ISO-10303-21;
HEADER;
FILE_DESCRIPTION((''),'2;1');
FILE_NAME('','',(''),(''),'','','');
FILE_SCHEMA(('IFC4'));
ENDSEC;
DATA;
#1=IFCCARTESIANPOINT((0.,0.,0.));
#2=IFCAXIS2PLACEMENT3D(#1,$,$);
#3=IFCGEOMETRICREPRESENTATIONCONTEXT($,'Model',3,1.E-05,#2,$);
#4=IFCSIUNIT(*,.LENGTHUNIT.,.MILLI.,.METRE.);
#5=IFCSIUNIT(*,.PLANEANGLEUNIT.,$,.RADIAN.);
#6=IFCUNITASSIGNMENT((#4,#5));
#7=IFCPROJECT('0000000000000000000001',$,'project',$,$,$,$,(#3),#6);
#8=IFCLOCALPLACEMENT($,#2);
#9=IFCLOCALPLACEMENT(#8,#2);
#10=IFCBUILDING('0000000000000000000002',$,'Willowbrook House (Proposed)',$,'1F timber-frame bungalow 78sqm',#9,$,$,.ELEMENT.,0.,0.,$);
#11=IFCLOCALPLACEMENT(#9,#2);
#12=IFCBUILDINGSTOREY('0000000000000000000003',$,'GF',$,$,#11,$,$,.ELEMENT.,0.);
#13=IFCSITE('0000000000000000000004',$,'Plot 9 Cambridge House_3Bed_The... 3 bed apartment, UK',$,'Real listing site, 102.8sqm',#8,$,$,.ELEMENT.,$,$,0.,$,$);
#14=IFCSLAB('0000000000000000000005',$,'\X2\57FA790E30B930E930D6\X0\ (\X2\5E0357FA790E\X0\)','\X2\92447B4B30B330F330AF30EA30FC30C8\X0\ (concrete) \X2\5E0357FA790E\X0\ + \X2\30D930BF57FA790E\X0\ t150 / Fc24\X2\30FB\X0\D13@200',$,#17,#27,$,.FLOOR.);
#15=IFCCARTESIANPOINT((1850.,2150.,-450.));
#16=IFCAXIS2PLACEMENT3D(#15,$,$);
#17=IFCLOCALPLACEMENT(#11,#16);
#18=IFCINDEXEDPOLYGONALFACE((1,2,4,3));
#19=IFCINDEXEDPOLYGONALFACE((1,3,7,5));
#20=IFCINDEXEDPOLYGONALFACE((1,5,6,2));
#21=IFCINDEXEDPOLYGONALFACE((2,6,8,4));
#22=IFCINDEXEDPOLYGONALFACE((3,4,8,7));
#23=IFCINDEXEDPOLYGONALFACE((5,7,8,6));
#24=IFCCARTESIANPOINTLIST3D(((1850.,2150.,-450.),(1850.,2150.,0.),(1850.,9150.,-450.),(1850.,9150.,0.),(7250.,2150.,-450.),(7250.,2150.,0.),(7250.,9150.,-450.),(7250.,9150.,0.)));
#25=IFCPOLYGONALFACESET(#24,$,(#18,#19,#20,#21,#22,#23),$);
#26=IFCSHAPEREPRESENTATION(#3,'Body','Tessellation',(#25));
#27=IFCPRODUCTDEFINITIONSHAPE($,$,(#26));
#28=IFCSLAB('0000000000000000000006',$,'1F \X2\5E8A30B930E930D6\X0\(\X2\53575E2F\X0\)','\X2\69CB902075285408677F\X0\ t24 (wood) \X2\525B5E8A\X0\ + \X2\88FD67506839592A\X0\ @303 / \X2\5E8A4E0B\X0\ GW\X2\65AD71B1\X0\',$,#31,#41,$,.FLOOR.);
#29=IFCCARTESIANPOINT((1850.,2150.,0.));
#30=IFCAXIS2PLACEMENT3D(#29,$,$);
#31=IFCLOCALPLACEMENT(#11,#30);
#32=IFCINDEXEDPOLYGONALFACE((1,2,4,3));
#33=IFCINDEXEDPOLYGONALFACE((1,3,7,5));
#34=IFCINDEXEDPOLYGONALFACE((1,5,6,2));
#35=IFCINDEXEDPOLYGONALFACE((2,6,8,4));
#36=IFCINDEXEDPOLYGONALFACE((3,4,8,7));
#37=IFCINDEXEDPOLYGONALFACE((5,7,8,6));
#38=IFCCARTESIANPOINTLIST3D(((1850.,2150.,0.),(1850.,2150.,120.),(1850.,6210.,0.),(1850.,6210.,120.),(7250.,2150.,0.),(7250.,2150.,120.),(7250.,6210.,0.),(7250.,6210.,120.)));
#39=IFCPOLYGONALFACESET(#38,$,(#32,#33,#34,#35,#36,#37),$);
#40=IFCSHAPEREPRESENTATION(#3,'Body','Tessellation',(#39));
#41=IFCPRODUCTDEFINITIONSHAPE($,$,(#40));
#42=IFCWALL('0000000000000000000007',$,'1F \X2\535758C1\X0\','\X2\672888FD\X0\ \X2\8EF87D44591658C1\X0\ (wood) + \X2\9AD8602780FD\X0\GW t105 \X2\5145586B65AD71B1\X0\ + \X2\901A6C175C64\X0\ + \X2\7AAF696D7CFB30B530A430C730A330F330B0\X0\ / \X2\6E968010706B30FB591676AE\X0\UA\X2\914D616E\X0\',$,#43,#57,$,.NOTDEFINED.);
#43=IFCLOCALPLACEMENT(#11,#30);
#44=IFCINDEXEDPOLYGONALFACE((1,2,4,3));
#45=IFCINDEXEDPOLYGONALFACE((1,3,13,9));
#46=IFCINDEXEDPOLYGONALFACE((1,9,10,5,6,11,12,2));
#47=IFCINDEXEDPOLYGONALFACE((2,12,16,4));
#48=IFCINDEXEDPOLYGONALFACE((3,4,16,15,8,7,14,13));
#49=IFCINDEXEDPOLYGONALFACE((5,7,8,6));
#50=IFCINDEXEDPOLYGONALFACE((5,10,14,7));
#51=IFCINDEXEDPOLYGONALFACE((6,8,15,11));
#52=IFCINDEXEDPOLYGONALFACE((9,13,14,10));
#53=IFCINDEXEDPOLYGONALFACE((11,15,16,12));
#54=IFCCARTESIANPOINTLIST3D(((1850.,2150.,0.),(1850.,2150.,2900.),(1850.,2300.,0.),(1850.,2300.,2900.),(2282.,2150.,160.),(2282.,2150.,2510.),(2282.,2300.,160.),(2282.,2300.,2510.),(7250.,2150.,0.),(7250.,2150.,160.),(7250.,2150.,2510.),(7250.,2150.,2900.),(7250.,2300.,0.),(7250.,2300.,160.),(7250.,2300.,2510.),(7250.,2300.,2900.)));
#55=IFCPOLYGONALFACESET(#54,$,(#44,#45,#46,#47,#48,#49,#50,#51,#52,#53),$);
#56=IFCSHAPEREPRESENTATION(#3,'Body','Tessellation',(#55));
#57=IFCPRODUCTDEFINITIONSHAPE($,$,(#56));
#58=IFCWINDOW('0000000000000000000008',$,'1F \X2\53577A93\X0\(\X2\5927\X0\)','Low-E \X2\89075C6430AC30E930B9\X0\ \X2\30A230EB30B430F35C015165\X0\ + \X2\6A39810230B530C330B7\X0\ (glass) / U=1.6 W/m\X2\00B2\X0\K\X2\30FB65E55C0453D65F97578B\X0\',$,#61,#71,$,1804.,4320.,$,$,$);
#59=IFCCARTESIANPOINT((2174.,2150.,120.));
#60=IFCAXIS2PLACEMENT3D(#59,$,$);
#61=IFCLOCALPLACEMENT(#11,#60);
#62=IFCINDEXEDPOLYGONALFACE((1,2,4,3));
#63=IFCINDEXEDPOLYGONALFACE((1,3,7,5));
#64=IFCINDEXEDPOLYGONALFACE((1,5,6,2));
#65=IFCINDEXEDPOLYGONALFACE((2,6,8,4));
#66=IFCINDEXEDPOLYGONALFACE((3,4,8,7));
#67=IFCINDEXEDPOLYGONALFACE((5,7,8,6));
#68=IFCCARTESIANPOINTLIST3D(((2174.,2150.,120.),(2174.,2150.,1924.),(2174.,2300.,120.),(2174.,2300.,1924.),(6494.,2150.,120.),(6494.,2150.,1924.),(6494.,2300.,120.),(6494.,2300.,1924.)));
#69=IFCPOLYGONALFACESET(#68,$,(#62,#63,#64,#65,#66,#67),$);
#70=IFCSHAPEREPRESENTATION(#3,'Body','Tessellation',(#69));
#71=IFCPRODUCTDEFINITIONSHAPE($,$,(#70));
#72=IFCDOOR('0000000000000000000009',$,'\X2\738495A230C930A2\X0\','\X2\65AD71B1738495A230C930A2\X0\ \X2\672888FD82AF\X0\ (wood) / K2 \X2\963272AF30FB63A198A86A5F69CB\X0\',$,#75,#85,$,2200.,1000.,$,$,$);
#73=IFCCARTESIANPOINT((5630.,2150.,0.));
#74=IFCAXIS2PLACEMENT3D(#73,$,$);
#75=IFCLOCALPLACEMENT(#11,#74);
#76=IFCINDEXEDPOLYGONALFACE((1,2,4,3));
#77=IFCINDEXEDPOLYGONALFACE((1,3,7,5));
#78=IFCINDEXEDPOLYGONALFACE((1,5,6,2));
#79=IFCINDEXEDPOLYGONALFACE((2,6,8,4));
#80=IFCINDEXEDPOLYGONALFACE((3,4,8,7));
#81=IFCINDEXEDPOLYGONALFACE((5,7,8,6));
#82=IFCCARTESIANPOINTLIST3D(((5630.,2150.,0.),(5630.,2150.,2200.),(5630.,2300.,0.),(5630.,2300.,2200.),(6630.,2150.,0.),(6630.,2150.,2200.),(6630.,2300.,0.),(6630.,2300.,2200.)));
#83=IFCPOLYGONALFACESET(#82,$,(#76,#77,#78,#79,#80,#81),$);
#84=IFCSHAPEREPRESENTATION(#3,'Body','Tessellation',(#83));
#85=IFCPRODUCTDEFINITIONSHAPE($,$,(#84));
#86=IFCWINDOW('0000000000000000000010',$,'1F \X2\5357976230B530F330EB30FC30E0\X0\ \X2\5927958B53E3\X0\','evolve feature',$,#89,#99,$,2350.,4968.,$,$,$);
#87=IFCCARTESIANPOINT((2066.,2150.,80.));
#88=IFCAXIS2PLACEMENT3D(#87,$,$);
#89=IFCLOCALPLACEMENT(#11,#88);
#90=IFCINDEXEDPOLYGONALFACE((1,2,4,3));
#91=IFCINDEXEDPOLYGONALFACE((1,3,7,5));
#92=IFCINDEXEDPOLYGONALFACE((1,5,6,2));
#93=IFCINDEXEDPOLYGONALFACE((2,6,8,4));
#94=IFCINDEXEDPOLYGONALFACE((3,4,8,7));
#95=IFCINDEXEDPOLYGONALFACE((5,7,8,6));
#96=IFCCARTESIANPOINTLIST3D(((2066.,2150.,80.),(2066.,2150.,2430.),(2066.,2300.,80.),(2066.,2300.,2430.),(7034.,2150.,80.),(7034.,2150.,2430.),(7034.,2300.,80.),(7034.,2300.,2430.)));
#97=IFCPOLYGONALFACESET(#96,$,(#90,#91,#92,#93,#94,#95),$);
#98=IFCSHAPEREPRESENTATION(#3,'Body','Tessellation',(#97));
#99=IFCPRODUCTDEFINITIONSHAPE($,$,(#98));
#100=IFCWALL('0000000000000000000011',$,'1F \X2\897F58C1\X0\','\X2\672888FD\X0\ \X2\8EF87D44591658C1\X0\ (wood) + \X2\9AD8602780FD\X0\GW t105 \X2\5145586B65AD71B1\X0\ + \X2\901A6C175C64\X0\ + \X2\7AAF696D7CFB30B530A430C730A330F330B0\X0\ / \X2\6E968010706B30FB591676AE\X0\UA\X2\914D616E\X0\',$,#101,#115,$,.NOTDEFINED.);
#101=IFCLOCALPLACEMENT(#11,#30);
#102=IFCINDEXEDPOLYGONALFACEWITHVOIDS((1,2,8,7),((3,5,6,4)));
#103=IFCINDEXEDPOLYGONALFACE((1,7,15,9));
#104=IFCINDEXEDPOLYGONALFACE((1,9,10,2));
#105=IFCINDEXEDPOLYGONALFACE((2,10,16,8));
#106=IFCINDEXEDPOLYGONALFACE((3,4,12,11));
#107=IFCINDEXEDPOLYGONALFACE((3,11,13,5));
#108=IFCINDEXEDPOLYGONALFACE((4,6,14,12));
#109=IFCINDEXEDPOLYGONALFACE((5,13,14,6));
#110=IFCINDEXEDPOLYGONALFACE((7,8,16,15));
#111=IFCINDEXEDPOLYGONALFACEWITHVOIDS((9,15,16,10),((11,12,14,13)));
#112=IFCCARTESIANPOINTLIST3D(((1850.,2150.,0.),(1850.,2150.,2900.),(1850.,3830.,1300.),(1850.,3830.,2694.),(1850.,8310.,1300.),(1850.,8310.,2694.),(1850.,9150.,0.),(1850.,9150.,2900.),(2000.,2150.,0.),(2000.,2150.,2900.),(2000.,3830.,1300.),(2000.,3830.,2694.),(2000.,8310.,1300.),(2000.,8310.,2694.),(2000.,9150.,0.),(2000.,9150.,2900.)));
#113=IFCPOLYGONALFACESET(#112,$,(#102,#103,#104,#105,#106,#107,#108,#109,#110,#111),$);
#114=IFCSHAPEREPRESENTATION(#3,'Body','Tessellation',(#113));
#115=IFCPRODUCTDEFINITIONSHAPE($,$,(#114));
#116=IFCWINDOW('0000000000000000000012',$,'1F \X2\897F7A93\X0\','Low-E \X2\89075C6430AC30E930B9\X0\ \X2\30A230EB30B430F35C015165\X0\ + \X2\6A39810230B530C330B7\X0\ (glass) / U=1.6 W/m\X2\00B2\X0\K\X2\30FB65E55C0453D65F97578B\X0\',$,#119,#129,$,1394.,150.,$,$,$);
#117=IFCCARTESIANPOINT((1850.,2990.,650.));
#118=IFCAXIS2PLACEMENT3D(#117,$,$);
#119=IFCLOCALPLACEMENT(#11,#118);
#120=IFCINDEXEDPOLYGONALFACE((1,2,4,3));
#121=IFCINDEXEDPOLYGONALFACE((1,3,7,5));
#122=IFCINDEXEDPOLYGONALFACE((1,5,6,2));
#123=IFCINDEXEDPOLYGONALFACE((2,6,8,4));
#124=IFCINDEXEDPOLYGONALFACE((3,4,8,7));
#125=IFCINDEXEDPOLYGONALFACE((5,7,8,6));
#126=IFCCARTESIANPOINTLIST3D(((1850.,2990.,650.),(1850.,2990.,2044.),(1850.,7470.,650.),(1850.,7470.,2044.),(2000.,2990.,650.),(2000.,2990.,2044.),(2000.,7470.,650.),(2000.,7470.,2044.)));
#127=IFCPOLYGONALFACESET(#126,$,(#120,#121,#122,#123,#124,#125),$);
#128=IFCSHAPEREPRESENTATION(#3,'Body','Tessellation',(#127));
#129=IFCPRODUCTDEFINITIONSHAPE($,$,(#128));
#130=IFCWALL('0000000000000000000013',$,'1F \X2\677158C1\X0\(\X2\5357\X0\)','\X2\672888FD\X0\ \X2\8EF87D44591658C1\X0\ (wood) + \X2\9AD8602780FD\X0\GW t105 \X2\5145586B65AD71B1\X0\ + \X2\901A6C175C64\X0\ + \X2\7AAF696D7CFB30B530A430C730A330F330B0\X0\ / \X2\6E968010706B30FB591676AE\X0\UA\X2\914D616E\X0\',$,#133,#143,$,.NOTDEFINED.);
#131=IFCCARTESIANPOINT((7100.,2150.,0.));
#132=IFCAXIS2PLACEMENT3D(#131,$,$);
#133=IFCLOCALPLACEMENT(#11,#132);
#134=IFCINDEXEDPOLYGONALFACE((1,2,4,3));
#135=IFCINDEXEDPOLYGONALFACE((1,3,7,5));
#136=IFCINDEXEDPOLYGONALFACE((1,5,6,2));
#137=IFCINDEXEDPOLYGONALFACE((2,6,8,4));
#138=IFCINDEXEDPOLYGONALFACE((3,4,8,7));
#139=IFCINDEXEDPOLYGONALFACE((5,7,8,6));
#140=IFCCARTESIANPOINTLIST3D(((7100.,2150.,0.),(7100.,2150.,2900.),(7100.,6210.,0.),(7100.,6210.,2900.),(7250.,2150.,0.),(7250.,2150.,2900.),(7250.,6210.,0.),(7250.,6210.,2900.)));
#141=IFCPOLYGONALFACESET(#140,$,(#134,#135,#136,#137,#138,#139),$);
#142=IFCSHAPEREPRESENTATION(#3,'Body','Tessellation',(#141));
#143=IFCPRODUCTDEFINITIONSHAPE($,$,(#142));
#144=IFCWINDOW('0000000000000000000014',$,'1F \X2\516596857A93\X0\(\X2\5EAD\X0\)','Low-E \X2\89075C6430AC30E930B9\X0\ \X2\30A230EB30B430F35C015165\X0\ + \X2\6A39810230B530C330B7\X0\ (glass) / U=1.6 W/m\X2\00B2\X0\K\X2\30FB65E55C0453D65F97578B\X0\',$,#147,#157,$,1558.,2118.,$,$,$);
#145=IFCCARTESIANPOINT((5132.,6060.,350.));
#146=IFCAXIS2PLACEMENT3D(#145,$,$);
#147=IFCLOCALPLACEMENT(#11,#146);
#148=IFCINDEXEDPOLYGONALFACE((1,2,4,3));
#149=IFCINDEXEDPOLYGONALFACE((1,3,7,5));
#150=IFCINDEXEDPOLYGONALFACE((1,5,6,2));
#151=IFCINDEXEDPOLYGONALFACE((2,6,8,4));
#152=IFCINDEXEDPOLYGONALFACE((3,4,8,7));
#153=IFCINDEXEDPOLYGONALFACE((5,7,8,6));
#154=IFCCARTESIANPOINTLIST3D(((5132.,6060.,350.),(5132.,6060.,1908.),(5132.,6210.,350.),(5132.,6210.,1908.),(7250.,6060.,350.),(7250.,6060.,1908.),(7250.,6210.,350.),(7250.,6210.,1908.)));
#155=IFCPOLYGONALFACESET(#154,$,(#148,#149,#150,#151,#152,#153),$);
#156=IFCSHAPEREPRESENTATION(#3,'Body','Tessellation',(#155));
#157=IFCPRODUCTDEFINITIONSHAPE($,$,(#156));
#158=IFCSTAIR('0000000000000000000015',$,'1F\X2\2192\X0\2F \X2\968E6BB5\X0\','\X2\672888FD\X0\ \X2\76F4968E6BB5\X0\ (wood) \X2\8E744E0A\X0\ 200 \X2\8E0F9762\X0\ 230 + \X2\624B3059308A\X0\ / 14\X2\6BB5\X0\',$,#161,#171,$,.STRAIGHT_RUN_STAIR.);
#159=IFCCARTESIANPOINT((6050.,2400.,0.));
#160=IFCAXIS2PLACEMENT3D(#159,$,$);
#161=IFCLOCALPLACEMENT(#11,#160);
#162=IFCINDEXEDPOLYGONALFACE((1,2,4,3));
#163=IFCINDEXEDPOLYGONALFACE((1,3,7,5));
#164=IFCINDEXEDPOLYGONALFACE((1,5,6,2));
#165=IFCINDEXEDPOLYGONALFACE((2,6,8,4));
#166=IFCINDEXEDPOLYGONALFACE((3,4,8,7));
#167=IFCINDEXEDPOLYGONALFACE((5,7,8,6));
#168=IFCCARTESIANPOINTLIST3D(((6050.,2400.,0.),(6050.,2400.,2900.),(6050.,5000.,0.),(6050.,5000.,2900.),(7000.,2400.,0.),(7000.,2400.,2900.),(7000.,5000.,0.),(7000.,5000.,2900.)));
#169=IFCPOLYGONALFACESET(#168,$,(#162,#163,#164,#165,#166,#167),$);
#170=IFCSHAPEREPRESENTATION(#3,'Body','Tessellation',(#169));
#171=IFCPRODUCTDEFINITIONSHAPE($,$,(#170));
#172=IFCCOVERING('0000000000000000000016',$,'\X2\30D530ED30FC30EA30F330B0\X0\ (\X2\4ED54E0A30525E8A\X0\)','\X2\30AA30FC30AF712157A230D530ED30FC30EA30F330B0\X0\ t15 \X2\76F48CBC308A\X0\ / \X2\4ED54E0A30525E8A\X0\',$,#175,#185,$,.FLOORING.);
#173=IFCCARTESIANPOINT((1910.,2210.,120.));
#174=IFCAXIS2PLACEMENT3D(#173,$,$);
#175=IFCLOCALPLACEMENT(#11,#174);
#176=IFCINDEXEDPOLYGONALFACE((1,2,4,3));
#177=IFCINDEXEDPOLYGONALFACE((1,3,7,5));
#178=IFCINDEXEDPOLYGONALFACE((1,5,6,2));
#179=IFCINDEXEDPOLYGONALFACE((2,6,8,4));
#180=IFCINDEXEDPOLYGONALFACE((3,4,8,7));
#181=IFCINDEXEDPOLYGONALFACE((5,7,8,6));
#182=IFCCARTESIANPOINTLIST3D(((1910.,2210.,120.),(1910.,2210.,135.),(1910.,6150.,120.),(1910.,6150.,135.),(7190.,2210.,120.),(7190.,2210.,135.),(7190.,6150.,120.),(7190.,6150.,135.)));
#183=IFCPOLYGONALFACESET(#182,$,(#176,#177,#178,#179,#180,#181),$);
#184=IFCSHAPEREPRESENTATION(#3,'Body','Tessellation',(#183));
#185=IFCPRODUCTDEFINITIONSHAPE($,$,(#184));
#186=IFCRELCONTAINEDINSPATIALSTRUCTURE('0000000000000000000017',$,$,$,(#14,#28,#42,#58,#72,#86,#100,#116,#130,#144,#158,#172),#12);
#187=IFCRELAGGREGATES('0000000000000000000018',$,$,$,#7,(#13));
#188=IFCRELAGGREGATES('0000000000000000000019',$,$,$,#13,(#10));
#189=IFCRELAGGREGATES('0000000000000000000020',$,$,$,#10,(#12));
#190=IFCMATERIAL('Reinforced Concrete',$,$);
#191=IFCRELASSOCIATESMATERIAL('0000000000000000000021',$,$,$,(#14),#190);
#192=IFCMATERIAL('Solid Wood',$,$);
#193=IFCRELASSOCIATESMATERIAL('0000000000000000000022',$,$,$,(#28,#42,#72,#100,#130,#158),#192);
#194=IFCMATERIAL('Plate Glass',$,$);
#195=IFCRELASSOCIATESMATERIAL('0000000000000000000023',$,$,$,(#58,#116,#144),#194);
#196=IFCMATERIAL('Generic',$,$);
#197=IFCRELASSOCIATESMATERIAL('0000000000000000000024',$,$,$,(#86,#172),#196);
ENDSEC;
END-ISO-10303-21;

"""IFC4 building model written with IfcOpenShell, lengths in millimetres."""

from ifc_helpers import new_model, si_unit, frame, frame_2d, origin, place, context, project, spatial, rectangle, extrude, material, element, fill, save


model = new_model("IFC4")

# Units and contexts
model_context = context("Model", 3, precision=1e-05, world=origin())
ifc_project = project(units=[si_unit("LENGTHUNIT", "METRE", prefix="MILLI"), si_unit("PLANEANGLEUNIT", "RADIAN")], contexts=[model_context])

# Site, building, storey
site_placement = place(None, origin())
site = spatial("IfcSite", under=ifc_project, at=site_placement, Name="Plot 9 Cambridge House_3Bed_The... 3 bed apartment, UK", ObjectType="Real listing site, 102.8sqm", CompositionType="ELEMENT", RefElevation=0.0)
building_placement = place(site_placement, origin())
building = spatial("IfcBuilding", under=site, at=building_placement, Name="Willowbrook House (Proposed)", ObjectType="1F timber-frame bungalow 78sqm", CompositionType="ELEMENT", ElevationOfRefHeight=0.0, ElevationOfTerrain=0.0)
storey_placement = place(building_placement, origin())
storey = spatial("IfcBuildingStorey", under=building, at=storey_placement, Name="GF", CompositionType="ELEMENT", Elevation=0.0)

# Slabs
ifc_material_1 = material(Name="Reinforced Concrete")
slab_1_placement = place(storey_placement, frame((1850.0, 2150.0, -450.0)))
element("IfcSlab", 1, at=slab_1_placement, inside=storey, material=ifc_material_1, Name="基礎スラブ (布基礎)", Description="鉄筋コンクリート (concrete) 布基礎 + ベタ基礎 t150 / Fc24・D13@200", PredefinedType="FLOOR", context=model_context, shape_type="SweptSolid", body=[
    extrude(rectangle(XDim=5400.0, YDim=7000.0, at=frame_2d((2700.0, 3500.0))), frame((1850.0, 2150.0, -450.0)), (0.0, 0.0, 1.0), 450.0),
])
ifc_material_2 = material(Name="Solid Wood")
slab_2_placement = place(storey_placement, frame((1850.0, 2150.0, 0.0)))
element("IfcSlab", 2, at=slab_2_placement, inside=storey, material=ifc_material_2, Name="1F 床スラブ(南帯)", Description="構造用合板 t24 (wood) 剛床 + 製材根太 @303 / 床下 GW断熱", PredefinedType="FLOOR", context=model_context, shape_type="SweptSolid", body=[
    extrude(rectangle(XDim=5400.0, YDim=4060.0, at=frame_2d((2700.0, 2030.0))), frame((1850.0, 2150.0, 0.0)), (0.0, 0.0, 1.0), 120.0),
])

# Wall, openings, windows, door
wall_1_placement = place(storey_placement, frame((1850.0, 2150.0, 0.0)))
wall_1 = element("IfcWall", 3, at=wall_1_placement, inside=storey, material=ifc_material_2, Name="1F 南壁", Description="木製 軸組外壁 (wood) + 高性能GW t105 充填断熱 + 通気層 + 窯業系サイディング / 準耐火・外皮UA配慮", PredefinedType="NOTDEFINED", context=model_context, shape_type="SweptSolid", body=[
    extrude(rectangle(XDim=5400.0, YDim=150.0, at=frame_2d((2700.0, 75.0))), frame((1850.0, 2150.0, 0.0)), (0.0, 0.0, 1.0), 2900.0),
])
opening_1_placement = place(storey_placement, frame((2174.0, 2150.0, 120.0)))
opening_1 = element("IfcOpeningElement", 4, at=opening_1_placement, cuts=wall_1, PredefinedType="NOTDEFINED", context=model_context, shape_type="SweptSolid", body=[
    extrude(rectangle(XDim=4320.0, YDim=150.0, at=frame_2d((2160.0, 75.0))), frame((2174.0, 2150.0, 120.0)), (0.0, 0.0, 1.0), 1804.0),
])
opening_2_placement = place(storey_placement, frame((5630.0, 2150.0, 0.0)))
opening_2 = element("IfcOpeningElement", 5, at=opening_2_placement, cuts=wall_1, PredefinedType="NOTDEFINED", context=model_context, shape_type="SweptSolid", body=[
    extrude(rectangle(XDim=1000.0, YDim=150.0, at=frame_2d((500.0, 75.0))), frame((5630.0, 2150.0, 0.0)), (0.0, 0.0, 1.0), 2200.0),
])
opening_3_placement = place(storey_placement, frame((2066.0, 2150.0, 80.0)))
opening_3 = element("IfcOpeningElement", 6, at=opening_3_placement, cuts=wall_1, PredefinedType="NOTDEFINED", context=model_context, shape_type="SweptSolid", body=[
    extrude(rectangle(XDim=4968.0, YDim=150.0, at=frame_2d((2484.0, 75.0))), frame((2066.0, 2150.0, 80.0)), (0.0, 0.0, 1.0), 2350.0),
])
ifc_material_3 = material(Name="Plate Glass")
window_1_placement = place(storey_placement, frame((2174.0, 2150.0, 120.0)))
window_1 = element("IfcWindow", 7, at=window_1_placement, inside=storey, material=ifc_material_3, Name="1F 南窓(大)", Description="Low-E 複層ガラス アルゴン封入 + 樹脂サッシ (glass) / U=1.6 W/m²K・日射取得型", OverallHeight=1804.0, OverallWidth=4320.0, context=model_context, shape_type="SweptSolid", body=[
    extrude(rectangle(XDim=4320.0, YDim=150.0, at=frame_2d((2160.0, 75.0))), frame((2174.0, 2150.0, 120.0)), (0.0, 0.0, 1.0), 1804.0),
])
fill(opening_1, window_1)
door_1_placement = place(storey_placement, frame((5630.0, 2150.0, 0.0)))
door_1 = element("IfcDoor", 8, at=door_1_placement, inside=storey, material=ifc_material_2, Name="玄関ドア", Description="断熱玄関ドア 木製芯 (wood) / K2 防犯・採風機構", OverallHeight=2200.0, OverallWidth=1000.0, context=model_context, shape_type="SweptSolid", body=[
    extrude(rectangle(XDim=1000.0, YDim=150.0, at=frame_2d((500.0, 75.0))), frame((5630.0, 2150.0, 0.0)), (0.0, 0.0, 1.0), 2200.0),
])
fill(opening_2, door_1)
ifc_material_4 = material(Name="Generic")
window_2_placement = place(storey_placement, frame((2066.0, 2150.0, 80.0)))
window_2 = element("IfcWindow", 9, at=window_2_placement, inside=storey, material=ifc_material_4, Name="1F 南面サンルーム 大開口", Description="evolve feature", OverallHeight=2350.0, OverallWidth=4968.0, context=model_context, shape_type="SweptSolid", body=[
    extrude(rectangle(XDim=4968.0, YDim=150.0, at=frame_2d((2484.0, 75.0))), frame((2066.0, 2150.0, 80.0)), (0.0, 0.0, 1.0), 2350.0),
])
fill(opening_3, window_2)

# Walls, openings, windows
wall_2_placement = place(storey_placement, frame((1850.0, 2150.0, 0.0)))
wall_2 = element("IfcWall", 10, at=wall_2_placement, inside=storey, material=ifc_material_2, Name="1F 西壁", Description="木製 軸組外壁 (wood) + 高性能GW t105 充填断熱 + 通気層 + 窯業系サイディング / 準耐火・外皮UA配慮", PredefinedType="NOTDEFINED", context=model_context, shape_type="SweptSolid", body=[
    extrude(rectangle(XDim=150.0, YDim=7000.0, at=frame_2d((75.0, 3500.0))), frame((1850.0, 2150.0, 0.0)), (0.0, 0.0, 1.0), 2900.0),
])
opening_4_placement = place(storey_placement, frame((1850.0, 2990.0, 650.0)))
opening_4 = element("IfcOpeningElement", 11, at=opening_4_placement, cuts=wall_2, PredefinedType="NOTDEFINED", context=model_context, shape_type="SweptSolid", body=[
    extrude(rectangle(XDim=150.0, YDim=4480.0, at=frame_2d((75.0, 2240.0))), frame((1850.0, 2990.0, 650.0)), (0.0, 0.0, 1.0), 1394.0),
])
window_3_placement = place(storey_placement, frame((1850.0, 2990.0, 650.0)))
window_3 = element("IfcWindow", 12, at=window_3_placement, inside=storey, material=ifc_material_3, Name="1F 西窓", Description="Low-E 複層ガラス アルゴン封入 + 樹脂サッシ (glass) / U=1.6 W/m²K・日射取得型", OverallHeight=1394.0, OverallWidth=150.0, context=model_context, shape_type="SweptSolid", body=[
    extrude(rectangle(XDim=150.0, YDim=4480.0, at=frame_2d((75.0, 2240.0))), frame((1850.0, 2990.0, 650.0)), (0.0, 0.0, 1.0), 1394.0),
])
fill(opening_4, window_3)
wall_3_placement = place(storey_placement, frame((7100.0, 2150.0, 0.0)))
wall_3 = element("IfcWall", 13, at=wall_3_placement, inside=storey, material=ifc_material_2, Name="1F 東壁(南)", Description="木製 軸組外壁 (wood) + 高性能GW t105 充填断熱 + 通気層 + 窯業系サイディング / 準耐火・外皮UA配慮", PredefinedType="NOTDEFINED", context=model_context, shape_type="SweptSolid", body=[
    extrude(rectangle(XDim=150.0, YDim=4060.0, at=frame_2d((75.0, 2030.0))), frame((7100.0, 2150.0, 0.0)), (0.0, 0.0, 1.0), 2900.0),
])
opening_5_placement = place(storey_placement, frame((5132.0, 6060.0, 350.0)))
opening_5 = element("IfcOpeningElement", 14, at=opening_5_placement, cuts=wall_3, PredefinedType="NOTDEFINED", context=model_context, shape_type="SweptSolid", body=[
    extrude(rectangle(XDim=2118.0, YDim=150.0, at=frame_2d((1059.0, 75.0))), frame((5132.0, 6060.0, 350.0)), (0.0, 0.0, 1.0), 1558.0),
])
window_4_placement = place(storey_placement, frame((5132.0, 6060.0, 350.0)))
window_4 = element("IfcWindow", 15, at=window_4_placement, inside=storey, material=ifc_material_3, Name="1F 入隅窓(庭)", Description="Low-E 複層ガラス アルゴン封入 + 樹脂サッシ (glass) / U=1.6 W/m²K・日射取得型", OverallHeight=1558.0, OverallWidth=2118.0, context=model_context, shape_type="SweptSolid", body=[
    extrude(rectangle(XDim=2118.0, YDim=150.0, at=frame_2d((1059.0, 75.0))), frame((5132.0, 6060.0, 350.0)), (0.0, 0.0, 1.0), 1558.0),
])
fill(opening_5, window_4)

# Stair
stair_placement = place(storey_placement, frame((6050.0, 2400.0, 0.0)))
element("IfcStair", 16, at=stair_placement, inside=storey, material=ifc_material_2, Name="1F→2F 階段", Description="木製 直階段 (wood) 蹴上 200 踏面 230 + 手すり / 14段", PredefinedType="STRAIGHT_RUN_STAIR", context=model_context, shape_type="SweptSolid", body=[
    extrude(rectangle(XDim=950.0, YDim=2600.0, at=frame_2d((475.0, 1300.0))), frame((6050.0, 2400.0, 0.0)), (0.0, 0.0, 1.0), 2900.0),
])

# Covering
covering_placement = place(storey_placement, frame((1910.0, 2210.0, 120.0)))
element("IfcCovering", 17, at=covering_placement, inside=storey, material=ifc_material_4, Name="フローリング (仕上げ床)", Description="オーク無垢フローリング t15 直貼り / 仕上げ床", PredefinedType="FLOORING", context=model_context, shape_type="SweptSolid", body=[
    extrude(rectangle(XDim=5280.0, YDim=3940.0, at=frame_2d((2640.0, 1970.0))), frame((1910.0, 2210.0, 120.0)), (0.0, 0.0, 1.0), 15.0),
])

save(model, "model.ifc")
